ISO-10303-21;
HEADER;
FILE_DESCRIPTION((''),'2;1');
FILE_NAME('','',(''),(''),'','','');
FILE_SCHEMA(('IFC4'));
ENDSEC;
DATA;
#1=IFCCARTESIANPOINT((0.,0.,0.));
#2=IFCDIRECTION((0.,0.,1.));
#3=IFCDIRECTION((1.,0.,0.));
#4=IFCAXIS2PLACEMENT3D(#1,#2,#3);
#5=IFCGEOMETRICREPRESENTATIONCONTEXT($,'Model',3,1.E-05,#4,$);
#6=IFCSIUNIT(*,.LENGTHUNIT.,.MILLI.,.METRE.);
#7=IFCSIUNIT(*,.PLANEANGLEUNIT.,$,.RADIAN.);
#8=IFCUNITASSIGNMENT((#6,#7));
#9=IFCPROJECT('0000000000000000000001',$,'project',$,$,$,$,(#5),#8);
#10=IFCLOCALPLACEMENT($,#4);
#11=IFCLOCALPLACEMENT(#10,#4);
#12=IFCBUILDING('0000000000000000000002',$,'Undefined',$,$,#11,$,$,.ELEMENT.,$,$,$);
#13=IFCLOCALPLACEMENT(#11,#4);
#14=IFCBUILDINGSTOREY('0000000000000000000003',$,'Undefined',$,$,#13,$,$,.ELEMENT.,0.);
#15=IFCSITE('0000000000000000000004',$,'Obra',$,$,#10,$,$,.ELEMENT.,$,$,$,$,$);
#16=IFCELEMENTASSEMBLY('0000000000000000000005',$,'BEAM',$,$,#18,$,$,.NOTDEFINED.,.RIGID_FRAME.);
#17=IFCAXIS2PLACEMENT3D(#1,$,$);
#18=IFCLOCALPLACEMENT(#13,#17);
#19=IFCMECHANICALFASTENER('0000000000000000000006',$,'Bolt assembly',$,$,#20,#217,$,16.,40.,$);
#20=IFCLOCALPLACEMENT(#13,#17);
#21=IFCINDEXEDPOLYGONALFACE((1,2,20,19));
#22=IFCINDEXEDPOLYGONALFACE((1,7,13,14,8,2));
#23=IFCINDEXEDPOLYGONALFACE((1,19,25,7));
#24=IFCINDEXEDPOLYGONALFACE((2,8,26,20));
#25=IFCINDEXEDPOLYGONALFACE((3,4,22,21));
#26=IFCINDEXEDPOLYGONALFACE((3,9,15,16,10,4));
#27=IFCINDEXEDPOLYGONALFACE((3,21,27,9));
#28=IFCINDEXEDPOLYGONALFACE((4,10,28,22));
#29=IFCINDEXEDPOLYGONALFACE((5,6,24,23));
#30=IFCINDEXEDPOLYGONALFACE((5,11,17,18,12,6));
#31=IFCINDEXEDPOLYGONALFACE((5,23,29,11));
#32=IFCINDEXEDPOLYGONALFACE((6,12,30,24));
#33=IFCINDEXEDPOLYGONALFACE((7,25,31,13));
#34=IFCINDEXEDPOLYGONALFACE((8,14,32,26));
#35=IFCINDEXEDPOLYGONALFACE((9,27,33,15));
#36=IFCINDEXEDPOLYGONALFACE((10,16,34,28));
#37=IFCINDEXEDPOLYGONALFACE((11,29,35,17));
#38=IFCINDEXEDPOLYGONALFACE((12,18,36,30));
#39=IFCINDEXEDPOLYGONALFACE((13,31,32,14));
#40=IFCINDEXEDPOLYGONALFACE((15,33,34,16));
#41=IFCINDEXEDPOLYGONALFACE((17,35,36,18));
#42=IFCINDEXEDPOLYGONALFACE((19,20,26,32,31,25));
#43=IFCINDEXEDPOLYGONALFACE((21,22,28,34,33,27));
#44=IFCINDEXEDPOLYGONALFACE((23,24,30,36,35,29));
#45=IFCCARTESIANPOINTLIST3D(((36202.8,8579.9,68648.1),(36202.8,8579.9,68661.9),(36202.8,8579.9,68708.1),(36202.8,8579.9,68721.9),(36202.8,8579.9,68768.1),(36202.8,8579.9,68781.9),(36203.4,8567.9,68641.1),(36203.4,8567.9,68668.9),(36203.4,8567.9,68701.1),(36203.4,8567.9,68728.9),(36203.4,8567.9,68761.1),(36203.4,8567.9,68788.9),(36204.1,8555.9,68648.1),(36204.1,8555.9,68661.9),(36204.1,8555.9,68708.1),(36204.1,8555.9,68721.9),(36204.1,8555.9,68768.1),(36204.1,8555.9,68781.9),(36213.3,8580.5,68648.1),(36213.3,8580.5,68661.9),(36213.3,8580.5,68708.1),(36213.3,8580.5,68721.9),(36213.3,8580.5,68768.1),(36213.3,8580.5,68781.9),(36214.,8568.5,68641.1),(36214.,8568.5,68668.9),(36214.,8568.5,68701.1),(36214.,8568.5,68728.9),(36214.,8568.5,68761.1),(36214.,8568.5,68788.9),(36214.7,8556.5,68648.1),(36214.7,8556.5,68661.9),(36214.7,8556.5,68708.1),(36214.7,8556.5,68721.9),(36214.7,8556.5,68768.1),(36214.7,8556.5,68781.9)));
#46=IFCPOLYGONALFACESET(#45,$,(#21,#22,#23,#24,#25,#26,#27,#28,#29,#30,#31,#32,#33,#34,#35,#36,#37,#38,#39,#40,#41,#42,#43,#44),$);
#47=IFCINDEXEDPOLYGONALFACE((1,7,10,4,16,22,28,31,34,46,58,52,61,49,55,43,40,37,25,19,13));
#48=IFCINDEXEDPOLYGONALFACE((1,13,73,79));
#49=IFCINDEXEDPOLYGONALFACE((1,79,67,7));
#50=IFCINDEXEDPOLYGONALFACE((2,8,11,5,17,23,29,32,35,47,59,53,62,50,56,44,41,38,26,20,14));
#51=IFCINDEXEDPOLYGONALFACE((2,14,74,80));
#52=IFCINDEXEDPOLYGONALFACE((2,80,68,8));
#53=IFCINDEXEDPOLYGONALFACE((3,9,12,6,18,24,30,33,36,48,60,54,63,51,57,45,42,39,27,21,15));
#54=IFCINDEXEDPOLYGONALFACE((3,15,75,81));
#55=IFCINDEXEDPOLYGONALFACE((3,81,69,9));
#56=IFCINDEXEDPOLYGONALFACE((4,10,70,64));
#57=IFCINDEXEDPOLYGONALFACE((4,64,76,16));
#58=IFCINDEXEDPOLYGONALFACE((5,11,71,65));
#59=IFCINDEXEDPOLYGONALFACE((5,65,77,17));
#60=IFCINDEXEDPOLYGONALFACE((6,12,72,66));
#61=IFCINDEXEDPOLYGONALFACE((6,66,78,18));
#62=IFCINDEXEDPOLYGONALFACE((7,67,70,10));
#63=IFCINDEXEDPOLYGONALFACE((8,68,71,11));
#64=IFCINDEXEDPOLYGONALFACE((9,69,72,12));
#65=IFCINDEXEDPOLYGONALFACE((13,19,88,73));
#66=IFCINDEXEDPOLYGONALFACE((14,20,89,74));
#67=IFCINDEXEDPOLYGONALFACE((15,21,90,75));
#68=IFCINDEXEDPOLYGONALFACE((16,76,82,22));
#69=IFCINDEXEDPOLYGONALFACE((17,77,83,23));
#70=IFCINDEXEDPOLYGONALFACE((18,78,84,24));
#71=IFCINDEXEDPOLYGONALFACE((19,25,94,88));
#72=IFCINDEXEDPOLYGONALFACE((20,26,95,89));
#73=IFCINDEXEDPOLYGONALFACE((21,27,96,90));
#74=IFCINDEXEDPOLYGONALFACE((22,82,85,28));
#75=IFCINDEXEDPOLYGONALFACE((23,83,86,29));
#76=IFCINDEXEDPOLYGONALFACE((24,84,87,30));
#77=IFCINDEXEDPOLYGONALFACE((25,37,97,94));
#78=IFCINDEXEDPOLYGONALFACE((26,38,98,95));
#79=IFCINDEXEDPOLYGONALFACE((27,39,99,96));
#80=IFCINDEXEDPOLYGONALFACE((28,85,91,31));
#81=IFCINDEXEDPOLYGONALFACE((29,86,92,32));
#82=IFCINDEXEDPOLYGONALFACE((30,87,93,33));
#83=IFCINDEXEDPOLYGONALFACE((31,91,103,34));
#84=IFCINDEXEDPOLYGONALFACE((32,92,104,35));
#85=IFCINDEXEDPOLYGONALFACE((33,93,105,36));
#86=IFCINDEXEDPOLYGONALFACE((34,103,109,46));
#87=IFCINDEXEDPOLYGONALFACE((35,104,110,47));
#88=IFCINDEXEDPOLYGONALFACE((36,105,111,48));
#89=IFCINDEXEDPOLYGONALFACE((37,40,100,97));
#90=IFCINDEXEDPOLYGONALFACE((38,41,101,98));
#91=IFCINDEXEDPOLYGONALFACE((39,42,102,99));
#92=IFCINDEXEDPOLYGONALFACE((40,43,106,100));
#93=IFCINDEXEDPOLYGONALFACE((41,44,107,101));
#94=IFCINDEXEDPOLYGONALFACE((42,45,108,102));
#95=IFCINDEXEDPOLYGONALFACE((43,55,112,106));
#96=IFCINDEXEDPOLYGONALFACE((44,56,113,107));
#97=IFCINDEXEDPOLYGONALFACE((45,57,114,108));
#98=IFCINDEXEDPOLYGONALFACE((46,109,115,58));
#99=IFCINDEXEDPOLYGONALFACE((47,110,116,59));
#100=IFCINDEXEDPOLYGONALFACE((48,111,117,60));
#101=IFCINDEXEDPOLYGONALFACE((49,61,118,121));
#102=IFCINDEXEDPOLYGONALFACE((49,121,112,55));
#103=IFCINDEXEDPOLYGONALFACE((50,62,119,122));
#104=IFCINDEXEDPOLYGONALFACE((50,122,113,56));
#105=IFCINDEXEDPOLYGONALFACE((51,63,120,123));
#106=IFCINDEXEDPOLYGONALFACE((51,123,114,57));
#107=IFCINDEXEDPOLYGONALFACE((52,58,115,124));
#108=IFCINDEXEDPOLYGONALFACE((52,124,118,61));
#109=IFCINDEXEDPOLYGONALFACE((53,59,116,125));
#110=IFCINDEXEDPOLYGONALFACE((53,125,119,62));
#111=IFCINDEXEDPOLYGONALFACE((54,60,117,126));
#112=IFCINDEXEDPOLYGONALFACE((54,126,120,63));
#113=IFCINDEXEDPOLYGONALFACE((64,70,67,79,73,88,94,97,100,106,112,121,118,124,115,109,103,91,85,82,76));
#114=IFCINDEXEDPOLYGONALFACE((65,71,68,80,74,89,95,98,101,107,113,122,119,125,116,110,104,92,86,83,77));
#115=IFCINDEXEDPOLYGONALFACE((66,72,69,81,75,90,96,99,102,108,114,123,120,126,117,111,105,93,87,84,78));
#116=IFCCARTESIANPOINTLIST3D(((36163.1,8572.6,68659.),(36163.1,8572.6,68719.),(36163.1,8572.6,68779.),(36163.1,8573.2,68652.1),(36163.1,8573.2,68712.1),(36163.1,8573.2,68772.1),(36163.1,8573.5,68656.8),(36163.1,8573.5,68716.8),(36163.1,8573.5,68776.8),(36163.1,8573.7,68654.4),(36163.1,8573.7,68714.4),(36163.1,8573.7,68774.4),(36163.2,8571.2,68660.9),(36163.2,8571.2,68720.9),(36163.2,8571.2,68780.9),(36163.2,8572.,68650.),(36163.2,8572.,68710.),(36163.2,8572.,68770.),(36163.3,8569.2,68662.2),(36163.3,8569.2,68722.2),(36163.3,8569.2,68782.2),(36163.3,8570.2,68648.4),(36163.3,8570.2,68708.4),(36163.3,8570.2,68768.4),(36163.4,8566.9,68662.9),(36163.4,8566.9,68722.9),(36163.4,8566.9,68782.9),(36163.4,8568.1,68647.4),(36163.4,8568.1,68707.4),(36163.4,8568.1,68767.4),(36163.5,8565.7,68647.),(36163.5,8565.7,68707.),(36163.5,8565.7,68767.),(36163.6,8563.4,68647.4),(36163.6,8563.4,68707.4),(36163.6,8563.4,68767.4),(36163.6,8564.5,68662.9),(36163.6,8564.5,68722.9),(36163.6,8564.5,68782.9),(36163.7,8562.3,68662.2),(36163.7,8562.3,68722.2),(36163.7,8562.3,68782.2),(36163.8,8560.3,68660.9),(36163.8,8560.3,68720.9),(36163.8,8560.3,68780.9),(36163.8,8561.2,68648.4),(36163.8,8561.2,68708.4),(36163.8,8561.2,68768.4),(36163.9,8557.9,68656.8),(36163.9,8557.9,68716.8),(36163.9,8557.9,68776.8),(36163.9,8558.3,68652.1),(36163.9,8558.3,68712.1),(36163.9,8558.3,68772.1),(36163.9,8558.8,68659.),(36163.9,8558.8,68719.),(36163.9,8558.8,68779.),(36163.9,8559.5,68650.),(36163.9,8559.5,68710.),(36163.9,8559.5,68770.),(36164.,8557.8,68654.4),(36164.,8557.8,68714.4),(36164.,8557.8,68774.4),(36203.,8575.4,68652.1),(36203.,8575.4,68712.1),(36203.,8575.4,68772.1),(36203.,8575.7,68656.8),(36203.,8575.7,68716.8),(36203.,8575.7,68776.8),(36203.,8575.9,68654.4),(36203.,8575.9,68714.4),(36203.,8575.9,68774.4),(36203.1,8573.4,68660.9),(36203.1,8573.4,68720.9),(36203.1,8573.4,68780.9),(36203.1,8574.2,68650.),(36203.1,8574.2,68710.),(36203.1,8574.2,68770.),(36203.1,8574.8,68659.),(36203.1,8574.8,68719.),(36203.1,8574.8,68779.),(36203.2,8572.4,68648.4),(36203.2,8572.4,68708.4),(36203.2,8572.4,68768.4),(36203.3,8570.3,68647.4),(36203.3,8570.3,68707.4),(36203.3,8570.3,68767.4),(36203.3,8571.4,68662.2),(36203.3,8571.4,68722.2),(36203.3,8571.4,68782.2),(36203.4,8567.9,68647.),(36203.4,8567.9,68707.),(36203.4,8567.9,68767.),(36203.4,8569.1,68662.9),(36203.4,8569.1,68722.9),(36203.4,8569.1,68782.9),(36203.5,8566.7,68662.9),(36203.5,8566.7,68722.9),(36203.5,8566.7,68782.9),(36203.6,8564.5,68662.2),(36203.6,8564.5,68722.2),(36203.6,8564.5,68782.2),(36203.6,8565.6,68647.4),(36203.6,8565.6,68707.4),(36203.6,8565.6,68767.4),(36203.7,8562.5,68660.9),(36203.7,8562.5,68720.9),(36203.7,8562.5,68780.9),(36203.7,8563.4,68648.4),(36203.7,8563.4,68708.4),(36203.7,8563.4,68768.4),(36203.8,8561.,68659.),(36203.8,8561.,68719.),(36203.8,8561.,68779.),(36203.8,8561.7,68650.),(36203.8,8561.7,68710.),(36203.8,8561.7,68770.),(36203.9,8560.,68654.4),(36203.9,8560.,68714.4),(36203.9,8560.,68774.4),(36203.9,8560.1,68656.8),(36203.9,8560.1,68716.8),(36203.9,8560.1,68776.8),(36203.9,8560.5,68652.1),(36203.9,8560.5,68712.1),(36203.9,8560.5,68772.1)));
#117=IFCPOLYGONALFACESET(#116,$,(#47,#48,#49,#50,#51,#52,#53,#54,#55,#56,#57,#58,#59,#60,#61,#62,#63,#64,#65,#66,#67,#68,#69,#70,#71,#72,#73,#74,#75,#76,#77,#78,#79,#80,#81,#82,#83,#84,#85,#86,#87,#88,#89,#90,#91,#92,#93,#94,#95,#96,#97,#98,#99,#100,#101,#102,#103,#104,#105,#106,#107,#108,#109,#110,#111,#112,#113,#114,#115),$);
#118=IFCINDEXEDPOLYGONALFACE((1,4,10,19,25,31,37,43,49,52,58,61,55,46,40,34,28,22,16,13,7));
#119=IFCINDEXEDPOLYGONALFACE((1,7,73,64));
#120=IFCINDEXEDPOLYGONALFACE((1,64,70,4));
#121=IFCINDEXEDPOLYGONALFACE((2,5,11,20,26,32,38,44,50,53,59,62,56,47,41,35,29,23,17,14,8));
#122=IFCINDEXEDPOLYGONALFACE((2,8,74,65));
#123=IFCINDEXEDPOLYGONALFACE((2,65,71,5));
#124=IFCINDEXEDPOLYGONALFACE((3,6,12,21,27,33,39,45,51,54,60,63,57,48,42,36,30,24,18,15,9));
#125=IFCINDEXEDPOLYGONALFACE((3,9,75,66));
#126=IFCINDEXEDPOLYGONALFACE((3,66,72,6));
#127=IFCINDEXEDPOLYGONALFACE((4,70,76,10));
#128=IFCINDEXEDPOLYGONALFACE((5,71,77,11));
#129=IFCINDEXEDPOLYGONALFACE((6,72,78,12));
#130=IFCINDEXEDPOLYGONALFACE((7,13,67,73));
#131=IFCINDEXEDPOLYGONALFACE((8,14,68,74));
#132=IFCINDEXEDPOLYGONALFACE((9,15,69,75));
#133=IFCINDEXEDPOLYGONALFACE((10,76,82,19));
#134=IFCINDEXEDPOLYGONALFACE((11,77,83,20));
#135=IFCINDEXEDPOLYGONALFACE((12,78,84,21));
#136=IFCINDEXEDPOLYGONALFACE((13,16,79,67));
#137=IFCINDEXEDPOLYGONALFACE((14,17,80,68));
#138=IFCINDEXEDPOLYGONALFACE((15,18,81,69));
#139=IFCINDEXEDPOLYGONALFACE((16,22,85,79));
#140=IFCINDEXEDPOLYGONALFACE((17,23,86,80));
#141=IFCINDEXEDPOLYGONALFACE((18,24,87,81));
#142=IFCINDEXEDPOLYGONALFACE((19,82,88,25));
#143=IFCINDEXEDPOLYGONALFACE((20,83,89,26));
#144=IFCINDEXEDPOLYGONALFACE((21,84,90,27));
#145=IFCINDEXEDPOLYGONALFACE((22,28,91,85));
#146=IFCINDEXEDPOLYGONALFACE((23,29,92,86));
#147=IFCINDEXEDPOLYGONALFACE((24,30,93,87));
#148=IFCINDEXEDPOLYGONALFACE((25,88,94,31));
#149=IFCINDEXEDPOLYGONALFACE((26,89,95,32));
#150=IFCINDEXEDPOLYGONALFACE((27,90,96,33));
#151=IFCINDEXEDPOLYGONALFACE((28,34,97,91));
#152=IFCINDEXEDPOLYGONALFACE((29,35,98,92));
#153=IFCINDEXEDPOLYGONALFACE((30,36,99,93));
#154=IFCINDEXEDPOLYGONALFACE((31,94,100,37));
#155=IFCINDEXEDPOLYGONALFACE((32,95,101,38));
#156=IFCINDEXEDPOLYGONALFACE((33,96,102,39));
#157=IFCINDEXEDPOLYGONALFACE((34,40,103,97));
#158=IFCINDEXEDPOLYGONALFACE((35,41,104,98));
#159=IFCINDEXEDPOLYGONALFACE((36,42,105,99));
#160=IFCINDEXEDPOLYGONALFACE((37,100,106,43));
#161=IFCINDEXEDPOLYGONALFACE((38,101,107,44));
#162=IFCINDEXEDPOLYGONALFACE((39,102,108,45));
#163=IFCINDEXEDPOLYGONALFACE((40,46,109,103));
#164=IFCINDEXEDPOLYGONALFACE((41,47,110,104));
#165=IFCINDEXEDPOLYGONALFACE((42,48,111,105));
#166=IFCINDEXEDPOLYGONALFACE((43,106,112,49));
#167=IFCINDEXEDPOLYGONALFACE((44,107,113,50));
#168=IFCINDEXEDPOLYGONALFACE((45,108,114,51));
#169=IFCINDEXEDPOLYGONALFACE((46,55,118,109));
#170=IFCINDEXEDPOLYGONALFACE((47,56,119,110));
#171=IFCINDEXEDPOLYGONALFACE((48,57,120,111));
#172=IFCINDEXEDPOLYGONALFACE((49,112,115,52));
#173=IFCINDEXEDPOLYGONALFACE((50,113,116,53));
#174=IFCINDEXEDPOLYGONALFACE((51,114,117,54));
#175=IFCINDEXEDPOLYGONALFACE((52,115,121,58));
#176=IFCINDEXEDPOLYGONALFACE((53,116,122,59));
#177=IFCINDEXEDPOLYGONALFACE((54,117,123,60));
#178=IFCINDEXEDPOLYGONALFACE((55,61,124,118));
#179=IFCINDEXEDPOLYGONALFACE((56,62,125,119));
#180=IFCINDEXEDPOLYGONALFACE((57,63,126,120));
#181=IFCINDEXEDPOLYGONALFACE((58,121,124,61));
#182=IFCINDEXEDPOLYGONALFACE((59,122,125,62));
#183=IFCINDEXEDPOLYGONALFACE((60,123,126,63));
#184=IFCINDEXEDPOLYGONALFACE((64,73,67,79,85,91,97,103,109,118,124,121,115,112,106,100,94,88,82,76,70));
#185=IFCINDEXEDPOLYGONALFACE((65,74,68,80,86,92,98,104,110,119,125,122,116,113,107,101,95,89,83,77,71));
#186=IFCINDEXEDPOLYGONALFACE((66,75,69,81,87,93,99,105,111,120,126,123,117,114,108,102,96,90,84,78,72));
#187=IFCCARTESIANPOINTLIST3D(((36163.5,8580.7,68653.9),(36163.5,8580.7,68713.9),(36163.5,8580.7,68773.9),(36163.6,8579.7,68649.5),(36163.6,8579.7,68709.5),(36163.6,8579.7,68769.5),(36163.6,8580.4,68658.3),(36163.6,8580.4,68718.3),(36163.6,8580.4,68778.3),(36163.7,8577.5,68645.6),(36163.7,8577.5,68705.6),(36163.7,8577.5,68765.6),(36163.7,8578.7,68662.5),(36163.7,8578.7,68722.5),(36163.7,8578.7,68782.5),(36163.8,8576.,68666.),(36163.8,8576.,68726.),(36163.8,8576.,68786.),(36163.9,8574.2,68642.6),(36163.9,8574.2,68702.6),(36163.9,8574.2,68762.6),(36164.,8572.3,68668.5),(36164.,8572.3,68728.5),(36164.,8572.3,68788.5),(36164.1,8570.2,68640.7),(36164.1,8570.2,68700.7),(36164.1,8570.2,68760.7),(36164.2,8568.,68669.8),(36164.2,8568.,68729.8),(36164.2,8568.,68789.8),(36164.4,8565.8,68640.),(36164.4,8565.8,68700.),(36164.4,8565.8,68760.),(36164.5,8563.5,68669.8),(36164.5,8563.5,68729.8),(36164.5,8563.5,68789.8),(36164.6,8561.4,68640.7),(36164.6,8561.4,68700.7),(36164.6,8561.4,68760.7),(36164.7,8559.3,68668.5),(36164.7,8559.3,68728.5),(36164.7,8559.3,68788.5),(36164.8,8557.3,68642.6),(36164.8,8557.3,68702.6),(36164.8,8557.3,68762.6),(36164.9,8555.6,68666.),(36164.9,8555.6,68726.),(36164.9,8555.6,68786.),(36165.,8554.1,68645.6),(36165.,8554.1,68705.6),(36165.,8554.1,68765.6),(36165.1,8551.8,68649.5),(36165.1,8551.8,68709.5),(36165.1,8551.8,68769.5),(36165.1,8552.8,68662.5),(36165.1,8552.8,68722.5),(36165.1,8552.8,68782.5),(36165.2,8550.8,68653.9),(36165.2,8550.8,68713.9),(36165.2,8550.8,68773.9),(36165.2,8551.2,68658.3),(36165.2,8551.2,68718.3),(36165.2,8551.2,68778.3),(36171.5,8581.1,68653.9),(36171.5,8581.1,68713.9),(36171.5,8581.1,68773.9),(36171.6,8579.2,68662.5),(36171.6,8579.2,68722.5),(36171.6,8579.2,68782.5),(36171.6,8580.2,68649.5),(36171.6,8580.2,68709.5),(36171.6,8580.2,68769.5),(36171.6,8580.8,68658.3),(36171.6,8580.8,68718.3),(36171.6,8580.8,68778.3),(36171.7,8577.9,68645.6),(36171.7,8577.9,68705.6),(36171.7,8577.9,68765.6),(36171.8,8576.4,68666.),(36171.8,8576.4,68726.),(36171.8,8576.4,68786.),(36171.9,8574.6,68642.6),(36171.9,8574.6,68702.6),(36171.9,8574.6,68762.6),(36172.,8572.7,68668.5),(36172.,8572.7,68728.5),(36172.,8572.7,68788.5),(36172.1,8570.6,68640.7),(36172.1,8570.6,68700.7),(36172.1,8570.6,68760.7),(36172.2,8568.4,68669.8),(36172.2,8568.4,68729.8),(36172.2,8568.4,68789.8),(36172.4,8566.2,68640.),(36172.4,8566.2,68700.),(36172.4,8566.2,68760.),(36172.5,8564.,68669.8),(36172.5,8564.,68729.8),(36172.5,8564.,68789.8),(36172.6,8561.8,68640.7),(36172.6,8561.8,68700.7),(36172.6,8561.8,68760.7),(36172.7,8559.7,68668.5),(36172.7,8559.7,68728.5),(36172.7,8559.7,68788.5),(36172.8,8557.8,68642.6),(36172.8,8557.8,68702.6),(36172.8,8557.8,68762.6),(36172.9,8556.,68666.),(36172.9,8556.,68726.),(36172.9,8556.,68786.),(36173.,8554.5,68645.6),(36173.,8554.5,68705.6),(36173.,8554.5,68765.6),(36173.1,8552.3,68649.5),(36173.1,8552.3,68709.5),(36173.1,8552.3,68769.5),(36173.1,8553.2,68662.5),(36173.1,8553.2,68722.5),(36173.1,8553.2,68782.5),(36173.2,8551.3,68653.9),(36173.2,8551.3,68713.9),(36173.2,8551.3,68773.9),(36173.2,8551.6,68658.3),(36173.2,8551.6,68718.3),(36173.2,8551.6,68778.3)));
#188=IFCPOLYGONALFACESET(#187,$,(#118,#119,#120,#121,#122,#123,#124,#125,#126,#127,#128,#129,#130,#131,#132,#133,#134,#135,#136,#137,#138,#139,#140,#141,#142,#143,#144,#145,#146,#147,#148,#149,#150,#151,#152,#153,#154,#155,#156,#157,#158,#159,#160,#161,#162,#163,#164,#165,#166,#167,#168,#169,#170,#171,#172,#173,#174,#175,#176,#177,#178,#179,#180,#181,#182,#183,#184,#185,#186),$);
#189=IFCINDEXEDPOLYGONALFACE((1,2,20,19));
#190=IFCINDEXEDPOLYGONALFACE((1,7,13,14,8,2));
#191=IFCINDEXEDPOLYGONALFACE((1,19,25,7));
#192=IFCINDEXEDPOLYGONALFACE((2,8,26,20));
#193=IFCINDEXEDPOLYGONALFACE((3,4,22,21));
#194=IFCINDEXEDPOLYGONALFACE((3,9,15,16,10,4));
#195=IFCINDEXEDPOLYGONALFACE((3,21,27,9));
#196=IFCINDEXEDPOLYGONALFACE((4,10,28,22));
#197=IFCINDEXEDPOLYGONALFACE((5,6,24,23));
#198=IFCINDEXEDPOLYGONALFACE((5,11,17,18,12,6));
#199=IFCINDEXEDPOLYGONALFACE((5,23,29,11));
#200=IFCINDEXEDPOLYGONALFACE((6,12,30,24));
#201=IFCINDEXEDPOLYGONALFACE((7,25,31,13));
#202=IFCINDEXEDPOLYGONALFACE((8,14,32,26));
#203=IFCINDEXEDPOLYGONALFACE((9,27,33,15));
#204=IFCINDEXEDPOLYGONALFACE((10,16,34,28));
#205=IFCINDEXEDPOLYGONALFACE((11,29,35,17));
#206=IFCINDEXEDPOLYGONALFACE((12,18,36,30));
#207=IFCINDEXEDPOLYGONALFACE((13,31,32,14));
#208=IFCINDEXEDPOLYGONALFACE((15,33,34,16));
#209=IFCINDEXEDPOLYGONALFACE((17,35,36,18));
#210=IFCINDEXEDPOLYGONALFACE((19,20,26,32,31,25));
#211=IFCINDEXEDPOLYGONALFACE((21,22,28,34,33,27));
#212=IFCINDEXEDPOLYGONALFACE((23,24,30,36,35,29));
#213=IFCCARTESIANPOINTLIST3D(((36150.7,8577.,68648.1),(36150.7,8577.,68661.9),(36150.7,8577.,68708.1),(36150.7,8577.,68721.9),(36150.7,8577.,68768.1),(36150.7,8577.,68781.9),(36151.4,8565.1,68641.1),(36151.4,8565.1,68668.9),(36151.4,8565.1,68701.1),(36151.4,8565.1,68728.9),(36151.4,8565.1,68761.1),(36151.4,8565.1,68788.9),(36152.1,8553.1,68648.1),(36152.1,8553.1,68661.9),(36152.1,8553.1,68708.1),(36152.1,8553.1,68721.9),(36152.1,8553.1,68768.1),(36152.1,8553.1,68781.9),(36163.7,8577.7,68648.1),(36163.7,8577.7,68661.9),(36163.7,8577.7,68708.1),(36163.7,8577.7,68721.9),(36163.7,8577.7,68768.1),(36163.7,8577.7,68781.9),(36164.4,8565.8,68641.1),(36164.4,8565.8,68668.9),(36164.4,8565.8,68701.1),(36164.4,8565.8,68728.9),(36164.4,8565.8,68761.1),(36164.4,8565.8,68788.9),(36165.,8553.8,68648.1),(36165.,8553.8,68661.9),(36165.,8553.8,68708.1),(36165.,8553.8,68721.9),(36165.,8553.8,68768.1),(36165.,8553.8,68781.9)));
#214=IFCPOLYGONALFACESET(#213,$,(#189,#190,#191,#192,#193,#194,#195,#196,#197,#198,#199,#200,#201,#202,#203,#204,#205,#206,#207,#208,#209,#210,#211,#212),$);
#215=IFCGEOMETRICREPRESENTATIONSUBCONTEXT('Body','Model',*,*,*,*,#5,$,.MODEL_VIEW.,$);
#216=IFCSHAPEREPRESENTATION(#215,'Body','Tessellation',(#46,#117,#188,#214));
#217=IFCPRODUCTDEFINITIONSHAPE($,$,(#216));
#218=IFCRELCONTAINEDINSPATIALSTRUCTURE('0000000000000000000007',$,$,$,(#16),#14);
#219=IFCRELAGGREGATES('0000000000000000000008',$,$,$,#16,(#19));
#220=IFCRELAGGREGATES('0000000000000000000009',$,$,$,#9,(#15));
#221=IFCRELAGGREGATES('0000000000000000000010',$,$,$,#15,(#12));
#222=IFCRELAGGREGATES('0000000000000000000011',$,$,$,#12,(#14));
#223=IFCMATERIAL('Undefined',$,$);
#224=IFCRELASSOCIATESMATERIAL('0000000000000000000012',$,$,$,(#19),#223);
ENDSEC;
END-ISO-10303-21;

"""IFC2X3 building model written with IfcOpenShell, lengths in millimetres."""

from ifc_helpers import new_model, si_unit, frame, origin_with_axes, origin_2d_with_axis, place, context, subcontext, project, spatial, polyline, circle, outline, extrude, source, transform, mapped, material, element, aggregate, save


model = new_model("IFC2X3")

# Units and contexts
model_context = context("Model", 3, precision=1e-05, world=origin_with_axes())
body_context = subcontext(model_context, "Body", "Model", "MODEL_VIEW")
ifc_project = project(units=[si_unit("LENGTHUNIT", "METRE", prefix="MILLI"), si_unit("PLANEANGLEUNIT", "RADIAN")], contexts=[model_context])

# Site, building, storey
site_placement = place(None, origin_with_axes())
site = spatial("IfcSite", under=ifc_project, at=site_placement, Name="Obra", CompositionType="ELEMENT")
building_placement = place(site_placement, origin_with_axes())
building = spatial("IfcBuilding", under=site, at=building_placement, Name="Undefined", CompositionType="ELEMENT")
storey_placement = place(building_placement, origin_with_axes())
storey = spatial("IfcBuildingStorey", under=building, at=storey_placement, Name="Undefined", CompositionType="ELEMENT", Elevation=0.0)

# Element assembly
assembly_1_placement = place(storey_placement, origin_with_axes())
assembly_1 = element("IfcElementAssembly", 1, at=assembly_1_placement, inside=storey, Name="BEAM", AssemblyPlace="NOTDEFINED", PredefinedType="RIGID_FRAME")

# Mechanical fastener
ifc_material_1 = material(Name="Undefined")
shared_shape_1 = source(origin_with_axes(), body_context, "Body", "SweptSolid", [
    extrude(outline(polyline([(13.9, 0.0), (6.9, 12.0), (-6.9, 12.0), (-13.9, 0.0), (-6.9, -12.0), (6.9, -12.0), (13.9, 0.0)])), frame((0.0, -44.8, 0.0), z_axis=(0.0, 1.0, 0.0), x_axis=(1.0, 0.0, 0.0)), (0.0, 0.0, 1.0), 10.6),
    extrude(circle(Radius=8.0, at=origin_2d_with_axis()), frame((0.0, -34.2, 0.0), z_axis=(0.0, 1.0, 0.0), x_axis=(1.0, 0.0, 0.0)), (0.0, 0.0, 1.0), 40.0),
    extrude(circle(Radius=15.0, at=origin_2d_with_axis()), frame((0.0, -3.1, 0.0), z_axis=(0.0, 1.0, 0.0), x_axis=(1.0, 0.0, 0.0)), (0.0, 0.0, 1.0), 8.0),
    extrude(outline(polyline([(13.9, 0.0), (6.9, 12.0), (-6.9, 12.0), (-13.9, 0.0), (-6.9, -12.0), (6.9, -12.0), (13.9, 0.0)])), frame((0.0, 4.9, 0.0), z_axis=(0.0, 1.0, 0.0), x_axis=(1.0, 0.0, 0.0)), (0.0, 0.0, 1.0), 13.0),
])
mechanical_fastener_1_placement = place(assembly_1_placement, frame((36172.0, 8516.1, 68835.0), z_axis=(-0.055152, 0.998478, 0.0), x_axis=(0.0, 0.0, -1.0)))
mechanical_fastener_1 = element("IfcMechanicalFastener", 2, at=mechanical_fastener_1_placement, material=ifc_material_1, Name="Bolt assembly", NominalDiameter=16.0, NominalLength=40.0, context=body_context, shape_type="MappedRepresentation", body=[
    mapped(shared_shape_1, transform((60.0, 0.0, 50.0))),
    mapped(shared_shape_1, transform((120.0, 0.0, 50.0))),
    mapped(shared_shape_1, transform((180.0, 0.0, 50.0))),
])
aggregate(assembly_1, [mechanical_fastener_1])

save(model, "model.ifc")
